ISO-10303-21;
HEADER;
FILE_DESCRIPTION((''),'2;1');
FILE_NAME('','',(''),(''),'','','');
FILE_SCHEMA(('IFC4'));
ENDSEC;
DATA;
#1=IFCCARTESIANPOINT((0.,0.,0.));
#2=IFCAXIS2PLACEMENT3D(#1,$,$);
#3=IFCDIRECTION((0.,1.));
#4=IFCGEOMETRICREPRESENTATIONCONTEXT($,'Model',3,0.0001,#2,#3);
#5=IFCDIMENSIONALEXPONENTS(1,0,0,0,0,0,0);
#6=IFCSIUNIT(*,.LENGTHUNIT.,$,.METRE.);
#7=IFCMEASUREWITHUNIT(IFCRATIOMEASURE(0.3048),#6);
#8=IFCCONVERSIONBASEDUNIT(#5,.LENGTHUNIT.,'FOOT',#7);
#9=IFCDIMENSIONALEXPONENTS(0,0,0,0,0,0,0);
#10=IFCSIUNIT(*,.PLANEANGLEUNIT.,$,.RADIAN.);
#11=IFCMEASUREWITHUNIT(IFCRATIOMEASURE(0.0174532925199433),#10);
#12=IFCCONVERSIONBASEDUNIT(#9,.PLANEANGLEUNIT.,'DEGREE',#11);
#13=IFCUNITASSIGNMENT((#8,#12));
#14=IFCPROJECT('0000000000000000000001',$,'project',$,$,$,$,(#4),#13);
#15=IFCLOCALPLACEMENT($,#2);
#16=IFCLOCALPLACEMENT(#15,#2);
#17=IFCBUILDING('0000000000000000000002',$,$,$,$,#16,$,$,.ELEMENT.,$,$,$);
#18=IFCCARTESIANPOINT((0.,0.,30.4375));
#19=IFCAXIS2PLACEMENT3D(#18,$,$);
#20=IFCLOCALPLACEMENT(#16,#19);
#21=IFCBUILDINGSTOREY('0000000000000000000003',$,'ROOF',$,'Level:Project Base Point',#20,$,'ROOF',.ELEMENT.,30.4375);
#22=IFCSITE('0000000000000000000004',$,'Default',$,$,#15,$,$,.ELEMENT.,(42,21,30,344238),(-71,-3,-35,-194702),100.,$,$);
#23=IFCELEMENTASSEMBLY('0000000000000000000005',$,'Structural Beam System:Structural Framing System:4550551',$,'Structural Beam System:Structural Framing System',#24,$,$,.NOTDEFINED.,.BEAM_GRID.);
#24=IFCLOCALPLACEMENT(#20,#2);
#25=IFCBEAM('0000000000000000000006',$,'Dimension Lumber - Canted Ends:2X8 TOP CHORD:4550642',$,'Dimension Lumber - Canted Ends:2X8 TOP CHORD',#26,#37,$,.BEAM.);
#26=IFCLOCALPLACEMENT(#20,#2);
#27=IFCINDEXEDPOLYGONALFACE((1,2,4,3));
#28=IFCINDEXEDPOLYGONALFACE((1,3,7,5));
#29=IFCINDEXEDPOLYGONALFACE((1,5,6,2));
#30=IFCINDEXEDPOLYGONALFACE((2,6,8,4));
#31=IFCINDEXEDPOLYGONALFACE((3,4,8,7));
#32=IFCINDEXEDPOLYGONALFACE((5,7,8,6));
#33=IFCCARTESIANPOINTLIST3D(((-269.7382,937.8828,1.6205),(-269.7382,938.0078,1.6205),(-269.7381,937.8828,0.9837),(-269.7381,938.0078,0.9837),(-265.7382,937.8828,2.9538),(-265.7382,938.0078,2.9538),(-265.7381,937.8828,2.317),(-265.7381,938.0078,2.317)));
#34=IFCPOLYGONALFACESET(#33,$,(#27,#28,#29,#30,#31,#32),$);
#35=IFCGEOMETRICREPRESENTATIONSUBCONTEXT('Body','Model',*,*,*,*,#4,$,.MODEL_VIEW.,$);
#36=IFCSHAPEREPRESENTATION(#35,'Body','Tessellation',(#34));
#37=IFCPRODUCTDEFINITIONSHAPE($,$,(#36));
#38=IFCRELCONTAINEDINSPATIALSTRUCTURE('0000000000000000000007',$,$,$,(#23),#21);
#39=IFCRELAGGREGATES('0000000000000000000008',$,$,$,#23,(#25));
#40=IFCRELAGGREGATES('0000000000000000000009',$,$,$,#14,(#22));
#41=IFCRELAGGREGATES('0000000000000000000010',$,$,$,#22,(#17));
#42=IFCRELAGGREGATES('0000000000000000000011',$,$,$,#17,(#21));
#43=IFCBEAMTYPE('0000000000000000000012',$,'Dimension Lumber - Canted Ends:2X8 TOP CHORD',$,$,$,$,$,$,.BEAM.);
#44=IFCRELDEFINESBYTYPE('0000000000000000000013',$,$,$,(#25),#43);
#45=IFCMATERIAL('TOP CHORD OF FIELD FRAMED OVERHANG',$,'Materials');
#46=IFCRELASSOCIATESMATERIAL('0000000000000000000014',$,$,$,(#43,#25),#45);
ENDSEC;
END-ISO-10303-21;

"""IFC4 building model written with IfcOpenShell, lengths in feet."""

from ifc_helpers import new_model, entity, si_unit, converted_unit, direction, frame, frame_2d, origin, origin_2d_with_axis, place, context, subcontext, project, spatial, rectangle, extrude, clip, halfspace, source, transform, mapped, material, material_profile, profile_set, profile_usage, type_object, type_shapes, element, aggregate, save


model = new_model("IFC4")

# Units and contexts
model_context = context("Model", 3, precision=0.0001, world=origin(), true_north=direction((0.0, 1.0)))
body_context = subcontext(model_context, "Body", "Model", "MODEL_VIEW")
ifc_project = project(units=[converted_unit("LENGTHUNIT", "FOOT", entity("IfcRatioMeasure", 0.3048), si_unit("LENGTHUNIT", "METRE"), dimensions=[1, 0, 0, 0, 0, 0, 0]), converted_unit("PLANEANGLEUNIT", "DEGREE", entity("IfcRatioMeasure", 0.0174532925199433), si_unit("PLANEANGLEUNIT", "RADIAN"), dimensions=[0, 0, 0, 0, 0, 0, 0])], contexts=[model_context])

# Site, building, storey
site_placement = place(None, origin())
site = spatial("IfcSite", under=ifc_project, at=site_placement, Name="Default", CompositionType="ELEMENT", RefLatitude=(42, 21, 30, 344238), RefLongitude=(-71, -3, -35, -194702), RefElevation=100.0)
building_placement = place(site_placement, origin())
building = spatial("IfcBuilding", under=site, at=building_placement, CompositionType="ELEMENT")
storey_placement = place(building_placement, frame((0.0, 0.0, 30.4375)))
storey = spatial("IfcBuildingStorey", under=building, at=storey_placement, Name="ROOF", ObjectType="Level:Project Base Point", LongName="ROOF", CompositionType="ELEMENT", Elevation=30.4375)

# Element assembly, beam
ifc_material_1 = material(Name="TOP CHORD OF FIELD FRAMED OVERHANG", Category="Materials")
ifc_material_profile_1 = material_profile(ifc_material_1, rectangle(XDim=0.6042, YDim=0.125, at=origin_2d_with_axis()), Name="2X8 TOP CHORD")
ifc_profile_set_1 = profile_set([ifc_material_profile_1], Name="2X8 TOP CHORD")
assembly_1_placement = place(storey_placement, origin())
assembly_1 = element("IfcElementAssembly", 1, at=assembly_1_placement, inside=storey, Name="Structural Beam System:Structural Framing System:4550551", ObjectType="Structural Beam System:Structural Framing System", AssemblyPlace="NOTDEFINED", PredefinedType="BEAM_GRID")
beam_type_1 = type_object("IfcBeamType", Name="Dimension Lumber - Canted Ends:2X8 TOP CHORD", PredefinedType="BEAM", material=ifc_profile_set_1)
shared_shape_1 = source(origin(), body_context, "Body", "Clipping", [
    clip(clip(extrude(rectangle(XDim=0.6042, YDim=0.125, at=frame_2d((0.0, 0.0), x_axis=(1.0, 0.0))), frame((-2.1082, 0.0, 0.0), z_axis=(1.0, 0.0, 0.0), x_axis=(0.0, 0.0, -1.0)), (0.0, 0.0, 1.0), 4.4177), halfspace(frame((2.1082, -0.0625, -0.3021), z_axis=(0.948711, 0.0, -0.316146), x_axis=(0.0, 1.0, 0.0)), False)), halfspace(frame((-1.9069, -0.0625, 0.3021), z_axis=(-0.948711, 0.0, 0.316146), x_axis=(0.0, 1.0, 0.0)), False)),
])
type_shapes(beam_type_1, [shared_shape_1])
ifc_profile_usage_1 = profile_usage(ifc_profile_set_1, cardinal=8)
beam_1_placement = place(assembly_1_placement, frame((-267.8337, 937.9453, 1.9369), z_axis=(-0.316228, 0.0, 0.948683), x_axis=(0.948683, 0.0, 0.316228)))
beam_1 = element("IfcBeam", 2, at=beam_1_placement, type_object=beam_type_1, material=ifc_profile_usage_1, Name="Dimension Lumber - Canted Ends:2X8 TOP CHORD:4550642", ObjectType="Dimension Lumber - Canted Ends:2X8 TOP CHORD", PredefinedType="BEAM", context=body_context, shape_type="MappedRepresentation", body=[
    mapped(shared_shape_1, transform((0.0, 0.0, 0.0), scale=1.0)),
])
aggregate(assembly_1, [beam_1])

save(model, "model.ifc")
